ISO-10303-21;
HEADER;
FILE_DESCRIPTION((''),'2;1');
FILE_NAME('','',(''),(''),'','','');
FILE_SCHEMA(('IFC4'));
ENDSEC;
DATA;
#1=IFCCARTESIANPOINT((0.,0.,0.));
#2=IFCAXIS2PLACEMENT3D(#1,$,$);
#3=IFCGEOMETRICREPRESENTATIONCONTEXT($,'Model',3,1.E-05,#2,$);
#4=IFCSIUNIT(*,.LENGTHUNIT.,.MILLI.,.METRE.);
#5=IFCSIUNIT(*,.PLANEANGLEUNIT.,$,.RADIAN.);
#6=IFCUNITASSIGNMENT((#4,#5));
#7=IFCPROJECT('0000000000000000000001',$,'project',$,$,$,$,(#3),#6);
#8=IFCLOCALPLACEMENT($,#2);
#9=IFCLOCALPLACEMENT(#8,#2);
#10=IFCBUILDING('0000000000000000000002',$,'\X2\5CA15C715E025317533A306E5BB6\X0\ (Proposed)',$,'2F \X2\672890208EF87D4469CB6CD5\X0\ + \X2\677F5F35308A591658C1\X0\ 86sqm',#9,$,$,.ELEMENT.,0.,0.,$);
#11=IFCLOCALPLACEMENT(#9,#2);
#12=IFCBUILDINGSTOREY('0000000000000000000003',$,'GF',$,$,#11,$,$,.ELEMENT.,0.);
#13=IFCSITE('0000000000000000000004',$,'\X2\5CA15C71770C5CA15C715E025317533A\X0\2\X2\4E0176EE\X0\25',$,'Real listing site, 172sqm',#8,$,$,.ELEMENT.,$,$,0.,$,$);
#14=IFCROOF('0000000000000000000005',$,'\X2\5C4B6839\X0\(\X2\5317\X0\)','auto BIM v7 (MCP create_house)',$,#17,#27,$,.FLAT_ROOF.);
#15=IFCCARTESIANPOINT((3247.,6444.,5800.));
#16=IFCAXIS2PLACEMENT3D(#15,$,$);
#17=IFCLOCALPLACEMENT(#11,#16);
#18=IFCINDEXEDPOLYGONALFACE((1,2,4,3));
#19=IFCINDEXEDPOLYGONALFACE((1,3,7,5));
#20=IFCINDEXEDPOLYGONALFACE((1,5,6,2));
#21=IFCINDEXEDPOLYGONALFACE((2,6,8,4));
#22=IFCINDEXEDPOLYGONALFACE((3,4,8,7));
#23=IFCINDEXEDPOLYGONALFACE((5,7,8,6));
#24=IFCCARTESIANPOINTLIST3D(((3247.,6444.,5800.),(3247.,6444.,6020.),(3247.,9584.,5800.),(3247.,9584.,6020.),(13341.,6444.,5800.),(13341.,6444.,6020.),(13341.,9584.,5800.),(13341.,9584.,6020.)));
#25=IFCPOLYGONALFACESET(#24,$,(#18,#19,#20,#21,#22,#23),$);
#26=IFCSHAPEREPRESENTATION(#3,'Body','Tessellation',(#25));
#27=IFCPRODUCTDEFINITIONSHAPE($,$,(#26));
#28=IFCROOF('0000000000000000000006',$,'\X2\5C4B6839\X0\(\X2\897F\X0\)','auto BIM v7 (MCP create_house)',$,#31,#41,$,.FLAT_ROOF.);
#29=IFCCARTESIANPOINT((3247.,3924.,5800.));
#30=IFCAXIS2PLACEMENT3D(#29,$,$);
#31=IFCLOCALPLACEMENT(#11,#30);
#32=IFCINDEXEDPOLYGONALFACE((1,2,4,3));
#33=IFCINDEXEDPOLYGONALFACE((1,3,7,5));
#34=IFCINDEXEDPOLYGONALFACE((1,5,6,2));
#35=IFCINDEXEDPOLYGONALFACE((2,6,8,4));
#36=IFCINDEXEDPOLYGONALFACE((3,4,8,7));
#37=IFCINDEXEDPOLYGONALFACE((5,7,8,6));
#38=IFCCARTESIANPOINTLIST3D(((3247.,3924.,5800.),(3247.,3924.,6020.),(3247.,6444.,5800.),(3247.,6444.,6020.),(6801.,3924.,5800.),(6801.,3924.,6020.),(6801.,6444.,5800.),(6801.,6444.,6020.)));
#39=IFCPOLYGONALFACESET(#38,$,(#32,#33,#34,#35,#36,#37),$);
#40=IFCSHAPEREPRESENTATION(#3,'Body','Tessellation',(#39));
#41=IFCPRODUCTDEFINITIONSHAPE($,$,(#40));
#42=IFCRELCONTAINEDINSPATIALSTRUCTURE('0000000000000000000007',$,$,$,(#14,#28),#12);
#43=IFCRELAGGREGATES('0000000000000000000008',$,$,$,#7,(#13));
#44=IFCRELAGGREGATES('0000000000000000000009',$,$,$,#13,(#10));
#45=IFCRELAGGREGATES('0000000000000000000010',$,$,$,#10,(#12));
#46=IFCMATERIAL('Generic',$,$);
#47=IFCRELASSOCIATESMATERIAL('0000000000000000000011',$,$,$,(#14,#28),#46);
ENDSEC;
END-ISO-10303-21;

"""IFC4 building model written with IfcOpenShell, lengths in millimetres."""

from ifc_helpers import new_model, si_unit, frame, frame_2d, origin, place, context, project, spatial, rectangle, extrude, material, element, save


model = new_model("IFC4")

# Units and contexts
model_context = context("Model", 3, precision=1e-05, world=origin())
ifc_project = project(units=[si_unit("LENGTHUNIT", "METRE", prefix="MILLI"), si_unit("PLANEANGLEUNIT", "RADIAN")], contexts=[model_context])

# Site, building, storey
site_placement = place(None, origin())
site = spatial("IfcSite", under=ifc_project, at=site_placement, Name="岡山県岡山市北区2丁目25", ObjectType="Real listing site, 172sqm", CompositionType="ELEMENT", RefElevation=0.0)
building_placement = place(site_placement, origin())
building = spatial("IfcBuilding", under=site, at=building_placement, Name="岡山市北区の家 (Proposed)", ObjectType="2F 木造軸組構法 + 板張り外壁 86sqm", CompositionType="ELEMENT", ElevationOfRefHeight=0.0, ElevationOfTerrain=0.0)
storey_placement = place(building_placement, origin())
storey = spatial("IfcBuildingStorey", under=building, at=storey_placement, Name="GF", CompositionType="ELEMENT", Elevation=0.0)

# Shared definitions
ifc_material = material(Name="Generic")

# Roofs
roof_1_placement = place(storey_placement, frame((3247.0, 6444.0, 5800.0)))
element("IfcRoof", 1, at=roof_1_placement, inside=storey, material=ifc_material, Name="屋根(北)", Description="auto BIM v7 (MCP create_house)", PredefinedType="FLAT_ROOF", context=model_context, shape_type="SweptSolid", body=[
    extrude(rectangle(XDim=10094.0, YDim=3140.0, at=frame_2d((5047.0, 1570.0))), frame((3247.0, 6444.0, 5800.0)), (0.0, 0.0, 1.0), 220.0),
])
roof_2_placement = place(storey_placement, frame((3247.0, 3924.0, 5800.0)))
element("IfcRoof", 2, at=roof_2_placement, inside=storey, material=ifc_material, Name="屋根(西)", Description="auto BIM v7 (MCP create_house)", PredefinedType="FLAT_ROOF", context=model_context, shape_type="SweptSolid", body=[
    extrude(rectangle(XDim=3554.0, YDim=2520.0, at=frame_2d((1777.0, 1260.0))), frame((3247.0, 3924.0, 5800.0)), (0.0, 0.0, 1.0), 220.0),
])

save(model, "model.ifc")
